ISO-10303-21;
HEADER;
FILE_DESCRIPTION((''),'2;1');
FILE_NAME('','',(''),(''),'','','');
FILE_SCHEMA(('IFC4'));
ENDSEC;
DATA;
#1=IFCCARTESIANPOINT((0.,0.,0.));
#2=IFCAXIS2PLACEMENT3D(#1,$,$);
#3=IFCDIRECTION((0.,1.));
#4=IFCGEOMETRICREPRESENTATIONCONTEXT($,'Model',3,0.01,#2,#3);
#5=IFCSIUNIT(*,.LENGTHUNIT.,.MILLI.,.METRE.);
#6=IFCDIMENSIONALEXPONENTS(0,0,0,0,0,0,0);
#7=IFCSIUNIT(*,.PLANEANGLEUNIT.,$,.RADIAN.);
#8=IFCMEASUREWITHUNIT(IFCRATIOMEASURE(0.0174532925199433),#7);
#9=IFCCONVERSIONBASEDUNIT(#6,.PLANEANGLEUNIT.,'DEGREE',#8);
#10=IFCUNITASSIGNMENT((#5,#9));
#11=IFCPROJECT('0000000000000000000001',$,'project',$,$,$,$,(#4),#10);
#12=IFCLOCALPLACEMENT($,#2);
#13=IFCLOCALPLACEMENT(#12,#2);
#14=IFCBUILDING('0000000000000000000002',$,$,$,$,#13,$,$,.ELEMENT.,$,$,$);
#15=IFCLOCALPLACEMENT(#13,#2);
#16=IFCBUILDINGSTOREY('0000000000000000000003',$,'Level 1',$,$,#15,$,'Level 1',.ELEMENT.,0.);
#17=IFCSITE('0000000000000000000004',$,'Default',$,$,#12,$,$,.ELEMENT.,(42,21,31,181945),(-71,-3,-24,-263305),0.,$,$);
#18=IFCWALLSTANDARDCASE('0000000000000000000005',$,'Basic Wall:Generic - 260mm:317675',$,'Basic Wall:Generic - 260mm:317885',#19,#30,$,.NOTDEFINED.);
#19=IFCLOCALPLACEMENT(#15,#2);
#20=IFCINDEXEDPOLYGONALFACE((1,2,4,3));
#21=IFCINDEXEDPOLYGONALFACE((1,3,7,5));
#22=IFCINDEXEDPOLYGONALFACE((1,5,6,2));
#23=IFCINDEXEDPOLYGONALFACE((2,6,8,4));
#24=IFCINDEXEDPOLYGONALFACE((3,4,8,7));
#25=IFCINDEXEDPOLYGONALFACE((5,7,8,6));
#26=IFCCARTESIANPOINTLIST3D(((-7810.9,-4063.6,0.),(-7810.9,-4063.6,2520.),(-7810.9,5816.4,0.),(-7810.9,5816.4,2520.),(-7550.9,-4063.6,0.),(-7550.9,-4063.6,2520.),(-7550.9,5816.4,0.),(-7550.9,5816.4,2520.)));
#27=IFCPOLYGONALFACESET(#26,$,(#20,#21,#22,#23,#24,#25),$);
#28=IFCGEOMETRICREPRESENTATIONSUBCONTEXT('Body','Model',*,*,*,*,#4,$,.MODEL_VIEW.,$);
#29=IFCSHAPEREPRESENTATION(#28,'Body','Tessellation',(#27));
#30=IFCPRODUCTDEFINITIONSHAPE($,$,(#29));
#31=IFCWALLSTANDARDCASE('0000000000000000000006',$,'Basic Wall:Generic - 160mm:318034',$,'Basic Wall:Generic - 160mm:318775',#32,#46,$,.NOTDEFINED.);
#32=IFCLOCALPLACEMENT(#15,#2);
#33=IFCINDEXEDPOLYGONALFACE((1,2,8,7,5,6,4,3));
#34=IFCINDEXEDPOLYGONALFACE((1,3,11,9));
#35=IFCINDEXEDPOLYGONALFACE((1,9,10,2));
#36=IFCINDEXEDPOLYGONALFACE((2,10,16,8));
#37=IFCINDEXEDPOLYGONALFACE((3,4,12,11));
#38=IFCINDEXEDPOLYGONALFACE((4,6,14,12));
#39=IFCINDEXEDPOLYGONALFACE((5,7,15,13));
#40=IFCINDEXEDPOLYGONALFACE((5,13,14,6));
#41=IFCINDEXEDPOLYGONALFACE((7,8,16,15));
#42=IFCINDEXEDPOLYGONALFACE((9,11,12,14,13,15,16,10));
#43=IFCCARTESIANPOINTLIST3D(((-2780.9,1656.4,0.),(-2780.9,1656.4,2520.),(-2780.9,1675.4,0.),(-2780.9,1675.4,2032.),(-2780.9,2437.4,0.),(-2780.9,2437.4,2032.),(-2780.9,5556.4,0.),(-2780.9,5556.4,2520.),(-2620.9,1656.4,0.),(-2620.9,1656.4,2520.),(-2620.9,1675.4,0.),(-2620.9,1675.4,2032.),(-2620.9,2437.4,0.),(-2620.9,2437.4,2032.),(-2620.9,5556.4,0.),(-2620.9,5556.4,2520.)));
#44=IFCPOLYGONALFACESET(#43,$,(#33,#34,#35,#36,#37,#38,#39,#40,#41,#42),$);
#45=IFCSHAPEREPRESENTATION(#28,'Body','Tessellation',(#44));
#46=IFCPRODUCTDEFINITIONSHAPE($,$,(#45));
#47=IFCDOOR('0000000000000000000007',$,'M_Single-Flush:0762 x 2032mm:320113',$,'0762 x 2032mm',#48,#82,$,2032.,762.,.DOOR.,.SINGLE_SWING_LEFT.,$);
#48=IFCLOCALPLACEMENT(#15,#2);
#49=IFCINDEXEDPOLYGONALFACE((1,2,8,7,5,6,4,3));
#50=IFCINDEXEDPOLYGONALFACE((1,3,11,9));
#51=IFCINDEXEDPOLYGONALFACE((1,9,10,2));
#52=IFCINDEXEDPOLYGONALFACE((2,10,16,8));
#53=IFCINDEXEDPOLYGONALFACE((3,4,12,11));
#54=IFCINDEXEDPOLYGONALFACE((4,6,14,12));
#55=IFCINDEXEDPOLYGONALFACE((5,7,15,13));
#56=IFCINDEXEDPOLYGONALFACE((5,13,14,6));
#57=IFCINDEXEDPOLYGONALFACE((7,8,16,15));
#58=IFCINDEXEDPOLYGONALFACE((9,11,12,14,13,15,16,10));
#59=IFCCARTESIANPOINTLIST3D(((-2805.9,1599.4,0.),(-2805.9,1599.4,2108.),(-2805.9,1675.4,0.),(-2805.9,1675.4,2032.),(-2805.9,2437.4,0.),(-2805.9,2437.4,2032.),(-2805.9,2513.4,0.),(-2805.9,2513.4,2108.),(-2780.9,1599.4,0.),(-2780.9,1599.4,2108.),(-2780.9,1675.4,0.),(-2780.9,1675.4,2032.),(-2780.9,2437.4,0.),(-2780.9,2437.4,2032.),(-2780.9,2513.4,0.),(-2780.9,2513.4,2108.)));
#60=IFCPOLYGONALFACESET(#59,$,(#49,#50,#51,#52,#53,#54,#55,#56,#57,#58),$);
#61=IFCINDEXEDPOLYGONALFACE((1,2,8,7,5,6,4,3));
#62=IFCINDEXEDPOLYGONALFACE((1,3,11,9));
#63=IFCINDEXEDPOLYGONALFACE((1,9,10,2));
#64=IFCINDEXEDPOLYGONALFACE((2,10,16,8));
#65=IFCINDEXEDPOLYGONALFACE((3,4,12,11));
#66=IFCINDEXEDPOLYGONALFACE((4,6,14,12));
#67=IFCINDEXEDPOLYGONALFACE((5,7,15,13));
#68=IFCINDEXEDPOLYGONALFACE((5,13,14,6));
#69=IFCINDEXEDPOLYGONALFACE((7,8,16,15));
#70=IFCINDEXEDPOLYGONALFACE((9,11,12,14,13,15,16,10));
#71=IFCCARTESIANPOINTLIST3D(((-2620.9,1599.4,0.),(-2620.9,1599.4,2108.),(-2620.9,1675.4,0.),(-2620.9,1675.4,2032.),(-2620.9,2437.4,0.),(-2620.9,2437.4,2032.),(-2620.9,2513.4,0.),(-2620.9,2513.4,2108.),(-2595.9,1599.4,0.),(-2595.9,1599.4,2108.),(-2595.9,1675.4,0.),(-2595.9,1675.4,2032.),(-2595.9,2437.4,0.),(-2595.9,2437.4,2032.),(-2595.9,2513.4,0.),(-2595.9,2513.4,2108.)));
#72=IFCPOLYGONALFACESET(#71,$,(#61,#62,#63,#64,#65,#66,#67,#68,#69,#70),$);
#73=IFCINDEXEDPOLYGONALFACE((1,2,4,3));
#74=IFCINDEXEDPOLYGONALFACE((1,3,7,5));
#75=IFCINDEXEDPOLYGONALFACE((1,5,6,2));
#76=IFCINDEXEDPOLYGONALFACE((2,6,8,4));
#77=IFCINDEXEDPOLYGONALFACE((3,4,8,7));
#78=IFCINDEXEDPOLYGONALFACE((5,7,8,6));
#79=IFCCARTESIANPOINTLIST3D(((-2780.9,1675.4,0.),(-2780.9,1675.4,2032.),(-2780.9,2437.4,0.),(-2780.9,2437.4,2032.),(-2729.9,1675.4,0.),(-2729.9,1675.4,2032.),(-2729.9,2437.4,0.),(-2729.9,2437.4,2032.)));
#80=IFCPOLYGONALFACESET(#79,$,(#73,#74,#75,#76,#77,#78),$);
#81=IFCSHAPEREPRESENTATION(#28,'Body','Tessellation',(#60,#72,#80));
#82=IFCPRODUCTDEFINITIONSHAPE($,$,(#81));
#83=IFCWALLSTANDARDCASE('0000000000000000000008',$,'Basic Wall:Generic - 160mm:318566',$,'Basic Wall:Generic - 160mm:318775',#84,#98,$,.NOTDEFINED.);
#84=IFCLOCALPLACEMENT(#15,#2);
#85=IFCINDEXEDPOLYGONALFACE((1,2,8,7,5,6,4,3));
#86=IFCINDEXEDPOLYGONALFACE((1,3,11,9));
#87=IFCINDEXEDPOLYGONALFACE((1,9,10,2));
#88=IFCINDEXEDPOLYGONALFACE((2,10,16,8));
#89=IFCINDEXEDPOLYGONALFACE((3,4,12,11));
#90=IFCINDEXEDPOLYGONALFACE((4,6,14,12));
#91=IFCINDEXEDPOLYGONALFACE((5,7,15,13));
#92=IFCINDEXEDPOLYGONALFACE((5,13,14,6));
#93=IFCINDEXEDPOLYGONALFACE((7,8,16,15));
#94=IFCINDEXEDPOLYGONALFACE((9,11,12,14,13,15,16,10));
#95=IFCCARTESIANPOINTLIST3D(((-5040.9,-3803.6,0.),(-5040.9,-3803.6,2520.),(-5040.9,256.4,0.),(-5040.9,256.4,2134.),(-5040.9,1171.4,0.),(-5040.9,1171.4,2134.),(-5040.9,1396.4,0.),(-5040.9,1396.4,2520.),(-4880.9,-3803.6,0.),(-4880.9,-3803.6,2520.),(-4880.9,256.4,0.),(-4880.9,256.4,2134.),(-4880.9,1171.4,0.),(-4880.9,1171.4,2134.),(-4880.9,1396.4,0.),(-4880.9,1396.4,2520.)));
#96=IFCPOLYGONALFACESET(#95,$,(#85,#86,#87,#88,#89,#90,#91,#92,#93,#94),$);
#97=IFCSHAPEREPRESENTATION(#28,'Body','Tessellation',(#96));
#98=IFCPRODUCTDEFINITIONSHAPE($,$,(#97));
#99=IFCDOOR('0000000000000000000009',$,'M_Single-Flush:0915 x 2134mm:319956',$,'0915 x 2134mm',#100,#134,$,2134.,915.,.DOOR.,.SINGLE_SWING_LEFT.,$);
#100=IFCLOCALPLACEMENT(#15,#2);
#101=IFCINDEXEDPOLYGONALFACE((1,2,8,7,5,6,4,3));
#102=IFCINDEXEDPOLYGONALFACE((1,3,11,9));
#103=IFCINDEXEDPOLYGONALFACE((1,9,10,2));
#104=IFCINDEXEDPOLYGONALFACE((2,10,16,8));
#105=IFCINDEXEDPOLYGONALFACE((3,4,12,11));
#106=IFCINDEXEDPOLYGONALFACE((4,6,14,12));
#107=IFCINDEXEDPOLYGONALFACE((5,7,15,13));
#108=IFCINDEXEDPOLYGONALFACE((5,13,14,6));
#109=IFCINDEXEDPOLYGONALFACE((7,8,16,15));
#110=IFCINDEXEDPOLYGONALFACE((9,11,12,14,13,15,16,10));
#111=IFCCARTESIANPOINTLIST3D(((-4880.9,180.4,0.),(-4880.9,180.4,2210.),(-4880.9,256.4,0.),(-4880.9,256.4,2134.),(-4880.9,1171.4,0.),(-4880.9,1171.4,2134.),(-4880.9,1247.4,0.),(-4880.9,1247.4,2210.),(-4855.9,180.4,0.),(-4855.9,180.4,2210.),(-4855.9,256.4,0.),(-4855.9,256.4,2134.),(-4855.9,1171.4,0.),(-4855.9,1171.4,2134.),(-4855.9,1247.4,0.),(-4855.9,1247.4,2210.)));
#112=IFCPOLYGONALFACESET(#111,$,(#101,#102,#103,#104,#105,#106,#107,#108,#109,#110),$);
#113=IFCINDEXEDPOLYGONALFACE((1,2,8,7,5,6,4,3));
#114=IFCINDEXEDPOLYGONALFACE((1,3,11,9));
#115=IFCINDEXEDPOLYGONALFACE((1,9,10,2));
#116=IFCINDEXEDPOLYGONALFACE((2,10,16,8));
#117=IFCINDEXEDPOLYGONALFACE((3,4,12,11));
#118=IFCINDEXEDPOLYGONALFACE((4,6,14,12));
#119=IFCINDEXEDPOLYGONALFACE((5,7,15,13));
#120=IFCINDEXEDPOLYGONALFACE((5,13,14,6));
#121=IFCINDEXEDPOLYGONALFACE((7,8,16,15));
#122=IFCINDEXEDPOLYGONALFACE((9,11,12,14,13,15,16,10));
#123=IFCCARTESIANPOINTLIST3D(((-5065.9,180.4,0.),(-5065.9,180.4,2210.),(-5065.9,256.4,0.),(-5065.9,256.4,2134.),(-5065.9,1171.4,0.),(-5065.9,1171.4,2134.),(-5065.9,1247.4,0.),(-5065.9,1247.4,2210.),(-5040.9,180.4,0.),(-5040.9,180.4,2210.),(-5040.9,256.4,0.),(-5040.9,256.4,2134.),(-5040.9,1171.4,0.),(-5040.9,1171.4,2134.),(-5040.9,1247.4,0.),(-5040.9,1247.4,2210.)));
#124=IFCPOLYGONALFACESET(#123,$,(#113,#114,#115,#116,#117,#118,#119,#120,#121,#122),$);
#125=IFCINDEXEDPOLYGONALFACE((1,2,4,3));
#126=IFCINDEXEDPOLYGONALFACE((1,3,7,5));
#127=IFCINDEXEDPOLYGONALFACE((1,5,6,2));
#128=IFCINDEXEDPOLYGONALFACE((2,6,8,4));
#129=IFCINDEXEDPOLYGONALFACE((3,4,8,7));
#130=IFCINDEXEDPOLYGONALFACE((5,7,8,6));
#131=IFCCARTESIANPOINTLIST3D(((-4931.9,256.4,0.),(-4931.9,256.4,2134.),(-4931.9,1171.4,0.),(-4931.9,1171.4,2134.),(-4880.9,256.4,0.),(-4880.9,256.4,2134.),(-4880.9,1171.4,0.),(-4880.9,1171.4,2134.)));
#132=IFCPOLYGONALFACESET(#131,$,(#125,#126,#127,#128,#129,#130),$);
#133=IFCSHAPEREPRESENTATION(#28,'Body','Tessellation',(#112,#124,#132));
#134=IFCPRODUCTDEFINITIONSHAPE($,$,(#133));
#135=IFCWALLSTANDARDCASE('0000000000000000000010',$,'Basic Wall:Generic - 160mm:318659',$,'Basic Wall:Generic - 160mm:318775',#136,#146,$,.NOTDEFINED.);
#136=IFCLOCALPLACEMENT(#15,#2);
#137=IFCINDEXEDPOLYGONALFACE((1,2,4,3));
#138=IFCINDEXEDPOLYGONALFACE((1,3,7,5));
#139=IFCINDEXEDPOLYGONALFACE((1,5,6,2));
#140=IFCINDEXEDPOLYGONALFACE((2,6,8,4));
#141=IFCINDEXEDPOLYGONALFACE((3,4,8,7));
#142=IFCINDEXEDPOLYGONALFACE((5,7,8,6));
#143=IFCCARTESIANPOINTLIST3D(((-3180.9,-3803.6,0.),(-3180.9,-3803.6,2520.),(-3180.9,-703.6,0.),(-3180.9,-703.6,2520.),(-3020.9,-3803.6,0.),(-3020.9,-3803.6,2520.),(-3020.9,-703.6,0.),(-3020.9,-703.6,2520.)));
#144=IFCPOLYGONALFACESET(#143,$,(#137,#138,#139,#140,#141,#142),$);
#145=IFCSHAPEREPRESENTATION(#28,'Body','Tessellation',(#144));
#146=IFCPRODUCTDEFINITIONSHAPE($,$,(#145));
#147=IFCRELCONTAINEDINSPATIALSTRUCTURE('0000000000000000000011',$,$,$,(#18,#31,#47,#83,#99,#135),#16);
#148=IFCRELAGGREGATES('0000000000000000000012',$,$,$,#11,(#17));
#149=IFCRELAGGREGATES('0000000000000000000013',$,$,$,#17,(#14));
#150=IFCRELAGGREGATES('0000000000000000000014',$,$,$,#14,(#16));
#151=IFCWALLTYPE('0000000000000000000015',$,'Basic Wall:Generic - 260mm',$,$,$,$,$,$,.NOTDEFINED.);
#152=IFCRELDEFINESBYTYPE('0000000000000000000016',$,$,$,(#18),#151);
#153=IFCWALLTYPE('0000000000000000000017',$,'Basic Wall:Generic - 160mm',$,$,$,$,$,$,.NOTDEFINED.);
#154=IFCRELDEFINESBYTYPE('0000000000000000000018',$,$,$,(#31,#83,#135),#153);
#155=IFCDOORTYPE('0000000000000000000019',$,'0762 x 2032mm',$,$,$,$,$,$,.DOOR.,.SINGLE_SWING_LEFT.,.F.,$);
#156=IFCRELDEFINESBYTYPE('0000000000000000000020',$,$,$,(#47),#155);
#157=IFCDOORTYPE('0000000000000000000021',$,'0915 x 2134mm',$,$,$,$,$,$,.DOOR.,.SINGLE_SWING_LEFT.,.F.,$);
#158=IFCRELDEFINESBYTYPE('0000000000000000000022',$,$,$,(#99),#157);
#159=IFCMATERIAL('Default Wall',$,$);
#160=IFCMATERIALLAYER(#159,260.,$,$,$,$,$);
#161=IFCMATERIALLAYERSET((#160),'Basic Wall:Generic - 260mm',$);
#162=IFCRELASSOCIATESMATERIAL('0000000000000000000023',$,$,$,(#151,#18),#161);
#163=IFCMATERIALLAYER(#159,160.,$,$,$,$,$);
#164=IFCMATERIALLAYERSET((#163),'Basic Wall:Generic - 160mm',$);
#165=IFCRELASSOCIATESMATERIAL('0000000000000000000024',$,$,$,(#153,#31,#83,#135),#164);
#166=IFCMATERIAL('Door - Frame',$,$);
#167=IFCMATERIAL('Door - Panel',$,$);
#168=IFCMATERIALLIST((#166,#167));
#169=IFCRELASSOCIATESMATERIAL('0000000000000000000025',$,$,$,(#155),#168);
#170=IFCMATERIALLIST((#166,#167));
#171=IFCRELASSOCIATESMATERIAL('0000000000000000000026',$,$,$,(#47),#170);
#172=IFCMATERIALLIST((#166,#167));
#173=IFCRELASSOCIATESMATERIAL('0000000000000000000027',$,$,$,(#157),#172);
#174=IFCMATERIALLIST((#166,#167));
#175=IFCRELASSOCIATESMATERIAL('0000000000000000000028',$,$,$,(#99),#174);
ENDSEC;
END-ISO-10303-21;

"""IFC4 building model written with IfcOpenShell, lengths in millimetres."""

from ifc_helpers import new_model, entity, si_unit, converted_unit, direction, frame, frame_2d, origin, place, context, subcontext, project, spatial, polyline, rectangle, outline, extrude, source, transform, mapped, material, material_list, layer, layer_set, layer_usage, type_object, type_shapes, element, fill, save


model = new_model("IFC4")

# Units and contexts
model_context = context("Model", 3, precision=0.01, world=origin(), true_north=direction((0.0, 1.0)))
body_context = subcontext(model_context, "Body", "Model", "MODEL_VIEW")
ifc_project = project(units=[si_unit("LENGTHUNIT", "METRE", prefix="MILLI"), converted_unit("PLANEANGLEUNIT", "DEGREE", entity("IfcRatioMeasure", 0.0174532925199433), si_unit("PLANEANGLEUNIT", "RADIAN"), dimensions=[0, 0, 0, 0, 0, 0, 0])], contexts=[model_context])

# Site, building, storey
site_placement = place(None, origin())
site = spatial("IfcSite", under=ifc_project, at=site_placement, Name="Default", CompositionType="ELEMENT", RefLatitude=(42, 21, 31, 181945), RefLongitude=(-71, -3, -24, -263305), RefElevation=0.0)
building_placement = place(site_placement, origin())
building = spatial("IfcBuilding", under=site, at=building_placement, CompositionType="ELEMENT")
storey_placement = place(building_placement, origin())
storey = spatial("IfcBuildingStorey", under=building, at=storey_placement, Name="Level 1", LongName="Level 1", CompositionType="ELEMENT", Elevation=0.0)

# Wall
ifc_material_1 = material(Name="Default Wall")
ifc_layer_1 = layer(ifc_material_1, 260.0)
ifc_layer_set_1 = layer_set([ifc_layer_1], Name="Basic Wall:Generic - 260mm")
ifc_layer_usage_1 = layer_usage(ifc_layer_set_1, "AXIS2", "NEGATIVE", 130.0)
wall_type_1 = type_object("IfcWallType", Name="Basic Wall:Generic - 260mm", PredefinedType="NOTDEFINED", material=ifc_layer_set_1)
wall_1_placement = place(storey_placement, frame((-7680.9, -4063.6, 0.0), z_axis=(0.0, 0.0, 1.0), x_axis=(0.0, 1.0, 0.0)))
element("IfcWallStandardCase", 1, at=wall_1_placement, inside=storey, type_object=wall_type_1, material=ifc_layer_usage_1, Name="Basic Wall:Generic - 260mm:317675", ObjectType="Basic Wall:Generic - 260mm:317885", PredefinedType="NOTDEFINED", context=body_context, shape_type="SweptSolid", body=[
    extrude(rectangle(XDim=9880.0, YDim=260.0, at=frame_2d((4940.0, 0.0), x_axis=(-1.0, 0.0))), origin(), (0.0, 0.0, 1.0), 2520.0),
])

# Walls, openings, doors
ifc_layer_2 = layer(ifc_material_1, 160.0)
ifc_layer_set_2 = layer_set([ifc_layer_2], Name="Basic Wall:Generic - 160mm")
ifc_layer_usage_2 = layer_usage(ifc_layer_set_2, "AXIS2", "POSITIVE", -80.0)
wall_type_2 = type_object("IfcWallType", Name="Basic Wall:Generic - 160mm", PredefinedType="NOTDEFINED", material=ifc_layer_set_2)
wall_2_placement = place(storey_placement, frame((-2700.9, 1656.4, 0.0), z_axis=(0.0, 0.0, 1.0), x_axis=(0.0, 1.0, 0.0)))
wall_2 = element("IfcWallStandardCase", 2, at=wall_2_placement, inside=storey, type_object=wall_type_2, material=ifc_layer_usage_2, Name="Basic Wall:Generic - 160mm:318034", ObjectType="Basic Wall:Generic - 160mm:318775", PredefinedType="NOTDEFINED", context=body_context, shape_type="SweptSolid", body=[
    extrude(rectangle(XDim=3900.0, YDim=160.0, at=frame_2d((1950.0, 0.0), x_axis=(-1.0, 0.0))), origin(), (0.0, 0.0, 1.0), 2520.0),
])
opening_1_placement = place(wall_2_placement, frame((19.0, -80.0, 0.0)))
opening_1 = element("IfcOpeningElement", 3, at=opening_1_placement, cuts=wall_2, ObjectType="Opening", PredefinedType="OPENING", context=body_context, shape_type="SweptSolid", body=[
    extrude(rectangle(XDim=762.0, YDim=2032.0, at=frame_2d((1016.0, 381.0), x_axis=(0.0, -1.0))), frame((0.0, 0.0, 0.0), z_axis=(0.0, 1.0, 0.0), x_axis=(0.0, 0.0, 1.0)), (0.0, 0.0, 1.0), 160.0),
])
ifc_material_2 = material(Name="Door - Frame")
ifc_material_3 = material(Name="Door - Panel")
ifc_material_list_1 = material_list([ifc_material_2, ifc_material_3])
ifc_material_list_2 = material_list([ifc_material_2, ifc_material_3])
door_type_1 = type_object("IfcDoorType", Name="0762 x 2032mm", OperationType="SINGLE_SWING_LEFT", ParameterTakesPrecedence=False, PredefinedType="DOOR", material=ifc_material_list_2)
shared_shape_1 = source(origin(), body_context, "Body", "SweptSolid", [
    extrude(outline(polyline([(-457.0, -1073.0), (457.0, -1073.0), (457.0, 1035.0), (381.0, 1035.0), (381.0, -997.0), (-381.0, -997.0), (-381.0, 1035.0), (-457.0, 1035.0), (-457.0, -1073.0)])), frame((381.0, 185.0, 1035.0), z_axis=(0.0, -1.0, 0.0), x_axis=(-1.0, 0.0, 0.0)), (0.0, 0.0, 1.0), 25.0),
    extrude(outline(polyline([(-1073.0, -457.0), (1035.0, -457.0), (1035.0, -381.0), (-997.0, -381.0), (-997.0, 381.0), (1035.0, 381.0), (1035.0, 457.0), (-1073.0, 457.0), (-1073.0, -457.0)])), frame((381.0, 0.0, 1035.0), z_axis=(0.0, -1.0, 0.0), x_axis=(0.0, 0.0, -1.0)), (0.0, 0.0, 1.0), 25.0),
    extrude(rectangle(XDim=762.0, YDim=51.0, at=frame_2d((0.0, 0.0), x_axis=(1.0, 0.0))), frame((381.0, 134.5, 0.0)), (0.0, 0.0, 1.0), 2032.0),
])
type_shapes(door_type_1, [shared_shape_1])
door_1_placement = place(opening_1_placement, origin())
door_1 = element("IfcDoor", 4, at=door_1_placement, inside=storey, type_object=door_type_1, material=ifc_material_list_1, Name="M_Single-Flush:0762 x 2032mm:320113", ObjectType="0762 x 2032mm", OperationType="SINGLE_SWING_LEFT", OverallHeight=2032.0, OverallWidth=762.0, PredefinedType="DOOR", context=body_context, shape_type="MappedRepresentation", body=[
    mapped(shared_shape_1, transform((0.0, 0.0, 0.0), scale=1.0)),
])
fill(opening_1, door_1)
ifc_layer_usage_3 = layer_usage(ifc_layer_set_2, "AXIS2", "POSITIVE", -80.0)
wall_3_placement = place(storey_placement, frame((-4960.9, -3803.6, 0.0), z_axis=(0.0, 0.0, 1.0), x_axis=(0.0, 1.0, 0.0)))
wall_3 = element("IfcWallStandardCase", 5, at=wall_3_placement, inside=storey, type_object=wall_type_2, material=ifc_layer_usage_3, Name="Basic Wall:Generic - 160mm:318566", ObjectType="Basic Wall:Generic - 160mm:318775", PredefinedType="NOTDEFINED", context=body_context, shape_type="SweptSolid", body=[
    extrude(rectangle(XDim=5200.0, YDim=160.0, at=frame_2d((2600.0, 0.0), x_axis=(-1.0, 0.0))), origin(), (0.0, 0.0, 1.0), 2520.0),
])
opening_2_placement = place(wall_3_placement, frame((4975.0, 80.0, 0.0)))
opening_2 = element("IfcOpeningElement", 6, at=opening_2_placement, cuts=wall_3, ObjectType="Opening", PredefinedType="OPENING", context=body_context, shape_type="SweptSolid", body=[
    extrude(rectangle(XDim=915.0, YDim=2134.0, at=frame_2d((1067.0, 457.5), x_axis=(0.0, -1.0))), frame((0.0, 0.0, 0.0), z_axis=(0.0, -1.0, 0.0), x_axis=(0.0, 0.0, 1.0)), (0.0, 0.0, 1.0), 160.0),
])
ifc_material_list_3 = material_list([ifc_material_2, ifc_material_3])
ifc_material_list_4 = material_list([ifc_material_2, ifc_material_3])
door_type_2 = type_object("IfcDoorType", Name="0915 x 2134mm", OperationType="SINGLE_SWING_LEFT", ParameterTakesPrecedence=False, PredefinedType="DOOR", material=ifc_material_list_4)
shared_shape_2 = source(origin(), body_context, "Body", "SweptSolid", [
    extrude(outline(polyline([(-533.5, -1124.0), (533.5, -1124.0), (533.5, 1086.0), (457.5, 1086.0), (457.5, -1048.0), (-457.5, -1048.0), (-457.5, 1086.0), (-533.5, 1086.0), (-533.5, -1124.0)])), frame((457.5, 185.0, 1086.0), z_axis=(0.0, -1.0, 0.0), x_axis=(-1.0, 0.0, 0.0)), (0.0, 0.0, 1.0), 25.0),
    extrude(outline(polyline([(-1124.0, -533.5), (1086.0, -533.5), (1086.0, -457.5), (-1048.0, -457.5), (-1048.0, 457.5), (1086.0, 457.5), (1086.0, 533.5), (-1124.0, 533.5), (-1124.0, -533.5)])), frame((457.5, 0.0, 1086.0), z_axis=(0.0, -1.0, 0.0), x_axis=(0.0, 0.0, -1.0)), (0.0, 0.0, 1.0), 25.0),
    extrude(rectangle(XDim=915.0, YDim=51.0, at=frame_2d((0.0, 0.0), x_axis=(1.0, 0.0))), frame((457.5, 134.5, 0.0)), (0.0, 0.0, 1.0), 2134.0),
])
type_shapes(door_type_2, [shared_shape_2])
door_2_placement = place(opening_2_placement, frame((0.0, 0.0, 0.0), z_axis=(0.0, 0.0, 1.0), x_axis=(-1.0, 0.0, 0.0)))
door_2 = element("IfcDoor", 7, at=door_2_placement, inside=storey, type_object=door_type_2, material=ifc_material_list_3, Name="M_Single-Flush:0915 x 2134mm:319956", ObjectType="0915 x 2134mm", OperationType="SINGLE_SWING_LEFT", OverallHeight=2134.0, OverallWidth=915.0, PredefinedType="DOOR", context=body_context, shape_type="MappedRepresentation", body=[
    mapped(shared_shape_2, transform((0.0, 0.0, 0.0), scale=1.0)),
])
fill(opening_2, door_2)

# Wall
ifc_layer_usage_4 = layer_usage(ifc_layer_set_2, "AXIS2", "POSITIVE", -80.0)
wall_4_placement = place(storey_placement, frame((-3100.9, -3803.6, 0.0), z_axis=(0.0, 0.0, 1.0), x_axis=(0.0, 1.0, 0.0)))
element("IfcWallStandardCase", 8, at=wall_4_placement, inside=storey, type_object=wall_type_2, material=ifc_layer_usage_4, Name="Basic Wall:Generic - 160mm:318659", ObjectType="Basic Wall:Generic - 160mm:318775", PredefinedType="NOTDEFINED", context=body_context, shape_type="SweptSolid", body=[
    extrude(rectangle(XDim=3100.0, YDim=160.0, at=frame_2d((1550.0, 0.0), x_axis=(-1.0, 0.0))), origin(), (0.0, 0.0, 1.0), 2520.0),
])

save(model, "model.ifc")
